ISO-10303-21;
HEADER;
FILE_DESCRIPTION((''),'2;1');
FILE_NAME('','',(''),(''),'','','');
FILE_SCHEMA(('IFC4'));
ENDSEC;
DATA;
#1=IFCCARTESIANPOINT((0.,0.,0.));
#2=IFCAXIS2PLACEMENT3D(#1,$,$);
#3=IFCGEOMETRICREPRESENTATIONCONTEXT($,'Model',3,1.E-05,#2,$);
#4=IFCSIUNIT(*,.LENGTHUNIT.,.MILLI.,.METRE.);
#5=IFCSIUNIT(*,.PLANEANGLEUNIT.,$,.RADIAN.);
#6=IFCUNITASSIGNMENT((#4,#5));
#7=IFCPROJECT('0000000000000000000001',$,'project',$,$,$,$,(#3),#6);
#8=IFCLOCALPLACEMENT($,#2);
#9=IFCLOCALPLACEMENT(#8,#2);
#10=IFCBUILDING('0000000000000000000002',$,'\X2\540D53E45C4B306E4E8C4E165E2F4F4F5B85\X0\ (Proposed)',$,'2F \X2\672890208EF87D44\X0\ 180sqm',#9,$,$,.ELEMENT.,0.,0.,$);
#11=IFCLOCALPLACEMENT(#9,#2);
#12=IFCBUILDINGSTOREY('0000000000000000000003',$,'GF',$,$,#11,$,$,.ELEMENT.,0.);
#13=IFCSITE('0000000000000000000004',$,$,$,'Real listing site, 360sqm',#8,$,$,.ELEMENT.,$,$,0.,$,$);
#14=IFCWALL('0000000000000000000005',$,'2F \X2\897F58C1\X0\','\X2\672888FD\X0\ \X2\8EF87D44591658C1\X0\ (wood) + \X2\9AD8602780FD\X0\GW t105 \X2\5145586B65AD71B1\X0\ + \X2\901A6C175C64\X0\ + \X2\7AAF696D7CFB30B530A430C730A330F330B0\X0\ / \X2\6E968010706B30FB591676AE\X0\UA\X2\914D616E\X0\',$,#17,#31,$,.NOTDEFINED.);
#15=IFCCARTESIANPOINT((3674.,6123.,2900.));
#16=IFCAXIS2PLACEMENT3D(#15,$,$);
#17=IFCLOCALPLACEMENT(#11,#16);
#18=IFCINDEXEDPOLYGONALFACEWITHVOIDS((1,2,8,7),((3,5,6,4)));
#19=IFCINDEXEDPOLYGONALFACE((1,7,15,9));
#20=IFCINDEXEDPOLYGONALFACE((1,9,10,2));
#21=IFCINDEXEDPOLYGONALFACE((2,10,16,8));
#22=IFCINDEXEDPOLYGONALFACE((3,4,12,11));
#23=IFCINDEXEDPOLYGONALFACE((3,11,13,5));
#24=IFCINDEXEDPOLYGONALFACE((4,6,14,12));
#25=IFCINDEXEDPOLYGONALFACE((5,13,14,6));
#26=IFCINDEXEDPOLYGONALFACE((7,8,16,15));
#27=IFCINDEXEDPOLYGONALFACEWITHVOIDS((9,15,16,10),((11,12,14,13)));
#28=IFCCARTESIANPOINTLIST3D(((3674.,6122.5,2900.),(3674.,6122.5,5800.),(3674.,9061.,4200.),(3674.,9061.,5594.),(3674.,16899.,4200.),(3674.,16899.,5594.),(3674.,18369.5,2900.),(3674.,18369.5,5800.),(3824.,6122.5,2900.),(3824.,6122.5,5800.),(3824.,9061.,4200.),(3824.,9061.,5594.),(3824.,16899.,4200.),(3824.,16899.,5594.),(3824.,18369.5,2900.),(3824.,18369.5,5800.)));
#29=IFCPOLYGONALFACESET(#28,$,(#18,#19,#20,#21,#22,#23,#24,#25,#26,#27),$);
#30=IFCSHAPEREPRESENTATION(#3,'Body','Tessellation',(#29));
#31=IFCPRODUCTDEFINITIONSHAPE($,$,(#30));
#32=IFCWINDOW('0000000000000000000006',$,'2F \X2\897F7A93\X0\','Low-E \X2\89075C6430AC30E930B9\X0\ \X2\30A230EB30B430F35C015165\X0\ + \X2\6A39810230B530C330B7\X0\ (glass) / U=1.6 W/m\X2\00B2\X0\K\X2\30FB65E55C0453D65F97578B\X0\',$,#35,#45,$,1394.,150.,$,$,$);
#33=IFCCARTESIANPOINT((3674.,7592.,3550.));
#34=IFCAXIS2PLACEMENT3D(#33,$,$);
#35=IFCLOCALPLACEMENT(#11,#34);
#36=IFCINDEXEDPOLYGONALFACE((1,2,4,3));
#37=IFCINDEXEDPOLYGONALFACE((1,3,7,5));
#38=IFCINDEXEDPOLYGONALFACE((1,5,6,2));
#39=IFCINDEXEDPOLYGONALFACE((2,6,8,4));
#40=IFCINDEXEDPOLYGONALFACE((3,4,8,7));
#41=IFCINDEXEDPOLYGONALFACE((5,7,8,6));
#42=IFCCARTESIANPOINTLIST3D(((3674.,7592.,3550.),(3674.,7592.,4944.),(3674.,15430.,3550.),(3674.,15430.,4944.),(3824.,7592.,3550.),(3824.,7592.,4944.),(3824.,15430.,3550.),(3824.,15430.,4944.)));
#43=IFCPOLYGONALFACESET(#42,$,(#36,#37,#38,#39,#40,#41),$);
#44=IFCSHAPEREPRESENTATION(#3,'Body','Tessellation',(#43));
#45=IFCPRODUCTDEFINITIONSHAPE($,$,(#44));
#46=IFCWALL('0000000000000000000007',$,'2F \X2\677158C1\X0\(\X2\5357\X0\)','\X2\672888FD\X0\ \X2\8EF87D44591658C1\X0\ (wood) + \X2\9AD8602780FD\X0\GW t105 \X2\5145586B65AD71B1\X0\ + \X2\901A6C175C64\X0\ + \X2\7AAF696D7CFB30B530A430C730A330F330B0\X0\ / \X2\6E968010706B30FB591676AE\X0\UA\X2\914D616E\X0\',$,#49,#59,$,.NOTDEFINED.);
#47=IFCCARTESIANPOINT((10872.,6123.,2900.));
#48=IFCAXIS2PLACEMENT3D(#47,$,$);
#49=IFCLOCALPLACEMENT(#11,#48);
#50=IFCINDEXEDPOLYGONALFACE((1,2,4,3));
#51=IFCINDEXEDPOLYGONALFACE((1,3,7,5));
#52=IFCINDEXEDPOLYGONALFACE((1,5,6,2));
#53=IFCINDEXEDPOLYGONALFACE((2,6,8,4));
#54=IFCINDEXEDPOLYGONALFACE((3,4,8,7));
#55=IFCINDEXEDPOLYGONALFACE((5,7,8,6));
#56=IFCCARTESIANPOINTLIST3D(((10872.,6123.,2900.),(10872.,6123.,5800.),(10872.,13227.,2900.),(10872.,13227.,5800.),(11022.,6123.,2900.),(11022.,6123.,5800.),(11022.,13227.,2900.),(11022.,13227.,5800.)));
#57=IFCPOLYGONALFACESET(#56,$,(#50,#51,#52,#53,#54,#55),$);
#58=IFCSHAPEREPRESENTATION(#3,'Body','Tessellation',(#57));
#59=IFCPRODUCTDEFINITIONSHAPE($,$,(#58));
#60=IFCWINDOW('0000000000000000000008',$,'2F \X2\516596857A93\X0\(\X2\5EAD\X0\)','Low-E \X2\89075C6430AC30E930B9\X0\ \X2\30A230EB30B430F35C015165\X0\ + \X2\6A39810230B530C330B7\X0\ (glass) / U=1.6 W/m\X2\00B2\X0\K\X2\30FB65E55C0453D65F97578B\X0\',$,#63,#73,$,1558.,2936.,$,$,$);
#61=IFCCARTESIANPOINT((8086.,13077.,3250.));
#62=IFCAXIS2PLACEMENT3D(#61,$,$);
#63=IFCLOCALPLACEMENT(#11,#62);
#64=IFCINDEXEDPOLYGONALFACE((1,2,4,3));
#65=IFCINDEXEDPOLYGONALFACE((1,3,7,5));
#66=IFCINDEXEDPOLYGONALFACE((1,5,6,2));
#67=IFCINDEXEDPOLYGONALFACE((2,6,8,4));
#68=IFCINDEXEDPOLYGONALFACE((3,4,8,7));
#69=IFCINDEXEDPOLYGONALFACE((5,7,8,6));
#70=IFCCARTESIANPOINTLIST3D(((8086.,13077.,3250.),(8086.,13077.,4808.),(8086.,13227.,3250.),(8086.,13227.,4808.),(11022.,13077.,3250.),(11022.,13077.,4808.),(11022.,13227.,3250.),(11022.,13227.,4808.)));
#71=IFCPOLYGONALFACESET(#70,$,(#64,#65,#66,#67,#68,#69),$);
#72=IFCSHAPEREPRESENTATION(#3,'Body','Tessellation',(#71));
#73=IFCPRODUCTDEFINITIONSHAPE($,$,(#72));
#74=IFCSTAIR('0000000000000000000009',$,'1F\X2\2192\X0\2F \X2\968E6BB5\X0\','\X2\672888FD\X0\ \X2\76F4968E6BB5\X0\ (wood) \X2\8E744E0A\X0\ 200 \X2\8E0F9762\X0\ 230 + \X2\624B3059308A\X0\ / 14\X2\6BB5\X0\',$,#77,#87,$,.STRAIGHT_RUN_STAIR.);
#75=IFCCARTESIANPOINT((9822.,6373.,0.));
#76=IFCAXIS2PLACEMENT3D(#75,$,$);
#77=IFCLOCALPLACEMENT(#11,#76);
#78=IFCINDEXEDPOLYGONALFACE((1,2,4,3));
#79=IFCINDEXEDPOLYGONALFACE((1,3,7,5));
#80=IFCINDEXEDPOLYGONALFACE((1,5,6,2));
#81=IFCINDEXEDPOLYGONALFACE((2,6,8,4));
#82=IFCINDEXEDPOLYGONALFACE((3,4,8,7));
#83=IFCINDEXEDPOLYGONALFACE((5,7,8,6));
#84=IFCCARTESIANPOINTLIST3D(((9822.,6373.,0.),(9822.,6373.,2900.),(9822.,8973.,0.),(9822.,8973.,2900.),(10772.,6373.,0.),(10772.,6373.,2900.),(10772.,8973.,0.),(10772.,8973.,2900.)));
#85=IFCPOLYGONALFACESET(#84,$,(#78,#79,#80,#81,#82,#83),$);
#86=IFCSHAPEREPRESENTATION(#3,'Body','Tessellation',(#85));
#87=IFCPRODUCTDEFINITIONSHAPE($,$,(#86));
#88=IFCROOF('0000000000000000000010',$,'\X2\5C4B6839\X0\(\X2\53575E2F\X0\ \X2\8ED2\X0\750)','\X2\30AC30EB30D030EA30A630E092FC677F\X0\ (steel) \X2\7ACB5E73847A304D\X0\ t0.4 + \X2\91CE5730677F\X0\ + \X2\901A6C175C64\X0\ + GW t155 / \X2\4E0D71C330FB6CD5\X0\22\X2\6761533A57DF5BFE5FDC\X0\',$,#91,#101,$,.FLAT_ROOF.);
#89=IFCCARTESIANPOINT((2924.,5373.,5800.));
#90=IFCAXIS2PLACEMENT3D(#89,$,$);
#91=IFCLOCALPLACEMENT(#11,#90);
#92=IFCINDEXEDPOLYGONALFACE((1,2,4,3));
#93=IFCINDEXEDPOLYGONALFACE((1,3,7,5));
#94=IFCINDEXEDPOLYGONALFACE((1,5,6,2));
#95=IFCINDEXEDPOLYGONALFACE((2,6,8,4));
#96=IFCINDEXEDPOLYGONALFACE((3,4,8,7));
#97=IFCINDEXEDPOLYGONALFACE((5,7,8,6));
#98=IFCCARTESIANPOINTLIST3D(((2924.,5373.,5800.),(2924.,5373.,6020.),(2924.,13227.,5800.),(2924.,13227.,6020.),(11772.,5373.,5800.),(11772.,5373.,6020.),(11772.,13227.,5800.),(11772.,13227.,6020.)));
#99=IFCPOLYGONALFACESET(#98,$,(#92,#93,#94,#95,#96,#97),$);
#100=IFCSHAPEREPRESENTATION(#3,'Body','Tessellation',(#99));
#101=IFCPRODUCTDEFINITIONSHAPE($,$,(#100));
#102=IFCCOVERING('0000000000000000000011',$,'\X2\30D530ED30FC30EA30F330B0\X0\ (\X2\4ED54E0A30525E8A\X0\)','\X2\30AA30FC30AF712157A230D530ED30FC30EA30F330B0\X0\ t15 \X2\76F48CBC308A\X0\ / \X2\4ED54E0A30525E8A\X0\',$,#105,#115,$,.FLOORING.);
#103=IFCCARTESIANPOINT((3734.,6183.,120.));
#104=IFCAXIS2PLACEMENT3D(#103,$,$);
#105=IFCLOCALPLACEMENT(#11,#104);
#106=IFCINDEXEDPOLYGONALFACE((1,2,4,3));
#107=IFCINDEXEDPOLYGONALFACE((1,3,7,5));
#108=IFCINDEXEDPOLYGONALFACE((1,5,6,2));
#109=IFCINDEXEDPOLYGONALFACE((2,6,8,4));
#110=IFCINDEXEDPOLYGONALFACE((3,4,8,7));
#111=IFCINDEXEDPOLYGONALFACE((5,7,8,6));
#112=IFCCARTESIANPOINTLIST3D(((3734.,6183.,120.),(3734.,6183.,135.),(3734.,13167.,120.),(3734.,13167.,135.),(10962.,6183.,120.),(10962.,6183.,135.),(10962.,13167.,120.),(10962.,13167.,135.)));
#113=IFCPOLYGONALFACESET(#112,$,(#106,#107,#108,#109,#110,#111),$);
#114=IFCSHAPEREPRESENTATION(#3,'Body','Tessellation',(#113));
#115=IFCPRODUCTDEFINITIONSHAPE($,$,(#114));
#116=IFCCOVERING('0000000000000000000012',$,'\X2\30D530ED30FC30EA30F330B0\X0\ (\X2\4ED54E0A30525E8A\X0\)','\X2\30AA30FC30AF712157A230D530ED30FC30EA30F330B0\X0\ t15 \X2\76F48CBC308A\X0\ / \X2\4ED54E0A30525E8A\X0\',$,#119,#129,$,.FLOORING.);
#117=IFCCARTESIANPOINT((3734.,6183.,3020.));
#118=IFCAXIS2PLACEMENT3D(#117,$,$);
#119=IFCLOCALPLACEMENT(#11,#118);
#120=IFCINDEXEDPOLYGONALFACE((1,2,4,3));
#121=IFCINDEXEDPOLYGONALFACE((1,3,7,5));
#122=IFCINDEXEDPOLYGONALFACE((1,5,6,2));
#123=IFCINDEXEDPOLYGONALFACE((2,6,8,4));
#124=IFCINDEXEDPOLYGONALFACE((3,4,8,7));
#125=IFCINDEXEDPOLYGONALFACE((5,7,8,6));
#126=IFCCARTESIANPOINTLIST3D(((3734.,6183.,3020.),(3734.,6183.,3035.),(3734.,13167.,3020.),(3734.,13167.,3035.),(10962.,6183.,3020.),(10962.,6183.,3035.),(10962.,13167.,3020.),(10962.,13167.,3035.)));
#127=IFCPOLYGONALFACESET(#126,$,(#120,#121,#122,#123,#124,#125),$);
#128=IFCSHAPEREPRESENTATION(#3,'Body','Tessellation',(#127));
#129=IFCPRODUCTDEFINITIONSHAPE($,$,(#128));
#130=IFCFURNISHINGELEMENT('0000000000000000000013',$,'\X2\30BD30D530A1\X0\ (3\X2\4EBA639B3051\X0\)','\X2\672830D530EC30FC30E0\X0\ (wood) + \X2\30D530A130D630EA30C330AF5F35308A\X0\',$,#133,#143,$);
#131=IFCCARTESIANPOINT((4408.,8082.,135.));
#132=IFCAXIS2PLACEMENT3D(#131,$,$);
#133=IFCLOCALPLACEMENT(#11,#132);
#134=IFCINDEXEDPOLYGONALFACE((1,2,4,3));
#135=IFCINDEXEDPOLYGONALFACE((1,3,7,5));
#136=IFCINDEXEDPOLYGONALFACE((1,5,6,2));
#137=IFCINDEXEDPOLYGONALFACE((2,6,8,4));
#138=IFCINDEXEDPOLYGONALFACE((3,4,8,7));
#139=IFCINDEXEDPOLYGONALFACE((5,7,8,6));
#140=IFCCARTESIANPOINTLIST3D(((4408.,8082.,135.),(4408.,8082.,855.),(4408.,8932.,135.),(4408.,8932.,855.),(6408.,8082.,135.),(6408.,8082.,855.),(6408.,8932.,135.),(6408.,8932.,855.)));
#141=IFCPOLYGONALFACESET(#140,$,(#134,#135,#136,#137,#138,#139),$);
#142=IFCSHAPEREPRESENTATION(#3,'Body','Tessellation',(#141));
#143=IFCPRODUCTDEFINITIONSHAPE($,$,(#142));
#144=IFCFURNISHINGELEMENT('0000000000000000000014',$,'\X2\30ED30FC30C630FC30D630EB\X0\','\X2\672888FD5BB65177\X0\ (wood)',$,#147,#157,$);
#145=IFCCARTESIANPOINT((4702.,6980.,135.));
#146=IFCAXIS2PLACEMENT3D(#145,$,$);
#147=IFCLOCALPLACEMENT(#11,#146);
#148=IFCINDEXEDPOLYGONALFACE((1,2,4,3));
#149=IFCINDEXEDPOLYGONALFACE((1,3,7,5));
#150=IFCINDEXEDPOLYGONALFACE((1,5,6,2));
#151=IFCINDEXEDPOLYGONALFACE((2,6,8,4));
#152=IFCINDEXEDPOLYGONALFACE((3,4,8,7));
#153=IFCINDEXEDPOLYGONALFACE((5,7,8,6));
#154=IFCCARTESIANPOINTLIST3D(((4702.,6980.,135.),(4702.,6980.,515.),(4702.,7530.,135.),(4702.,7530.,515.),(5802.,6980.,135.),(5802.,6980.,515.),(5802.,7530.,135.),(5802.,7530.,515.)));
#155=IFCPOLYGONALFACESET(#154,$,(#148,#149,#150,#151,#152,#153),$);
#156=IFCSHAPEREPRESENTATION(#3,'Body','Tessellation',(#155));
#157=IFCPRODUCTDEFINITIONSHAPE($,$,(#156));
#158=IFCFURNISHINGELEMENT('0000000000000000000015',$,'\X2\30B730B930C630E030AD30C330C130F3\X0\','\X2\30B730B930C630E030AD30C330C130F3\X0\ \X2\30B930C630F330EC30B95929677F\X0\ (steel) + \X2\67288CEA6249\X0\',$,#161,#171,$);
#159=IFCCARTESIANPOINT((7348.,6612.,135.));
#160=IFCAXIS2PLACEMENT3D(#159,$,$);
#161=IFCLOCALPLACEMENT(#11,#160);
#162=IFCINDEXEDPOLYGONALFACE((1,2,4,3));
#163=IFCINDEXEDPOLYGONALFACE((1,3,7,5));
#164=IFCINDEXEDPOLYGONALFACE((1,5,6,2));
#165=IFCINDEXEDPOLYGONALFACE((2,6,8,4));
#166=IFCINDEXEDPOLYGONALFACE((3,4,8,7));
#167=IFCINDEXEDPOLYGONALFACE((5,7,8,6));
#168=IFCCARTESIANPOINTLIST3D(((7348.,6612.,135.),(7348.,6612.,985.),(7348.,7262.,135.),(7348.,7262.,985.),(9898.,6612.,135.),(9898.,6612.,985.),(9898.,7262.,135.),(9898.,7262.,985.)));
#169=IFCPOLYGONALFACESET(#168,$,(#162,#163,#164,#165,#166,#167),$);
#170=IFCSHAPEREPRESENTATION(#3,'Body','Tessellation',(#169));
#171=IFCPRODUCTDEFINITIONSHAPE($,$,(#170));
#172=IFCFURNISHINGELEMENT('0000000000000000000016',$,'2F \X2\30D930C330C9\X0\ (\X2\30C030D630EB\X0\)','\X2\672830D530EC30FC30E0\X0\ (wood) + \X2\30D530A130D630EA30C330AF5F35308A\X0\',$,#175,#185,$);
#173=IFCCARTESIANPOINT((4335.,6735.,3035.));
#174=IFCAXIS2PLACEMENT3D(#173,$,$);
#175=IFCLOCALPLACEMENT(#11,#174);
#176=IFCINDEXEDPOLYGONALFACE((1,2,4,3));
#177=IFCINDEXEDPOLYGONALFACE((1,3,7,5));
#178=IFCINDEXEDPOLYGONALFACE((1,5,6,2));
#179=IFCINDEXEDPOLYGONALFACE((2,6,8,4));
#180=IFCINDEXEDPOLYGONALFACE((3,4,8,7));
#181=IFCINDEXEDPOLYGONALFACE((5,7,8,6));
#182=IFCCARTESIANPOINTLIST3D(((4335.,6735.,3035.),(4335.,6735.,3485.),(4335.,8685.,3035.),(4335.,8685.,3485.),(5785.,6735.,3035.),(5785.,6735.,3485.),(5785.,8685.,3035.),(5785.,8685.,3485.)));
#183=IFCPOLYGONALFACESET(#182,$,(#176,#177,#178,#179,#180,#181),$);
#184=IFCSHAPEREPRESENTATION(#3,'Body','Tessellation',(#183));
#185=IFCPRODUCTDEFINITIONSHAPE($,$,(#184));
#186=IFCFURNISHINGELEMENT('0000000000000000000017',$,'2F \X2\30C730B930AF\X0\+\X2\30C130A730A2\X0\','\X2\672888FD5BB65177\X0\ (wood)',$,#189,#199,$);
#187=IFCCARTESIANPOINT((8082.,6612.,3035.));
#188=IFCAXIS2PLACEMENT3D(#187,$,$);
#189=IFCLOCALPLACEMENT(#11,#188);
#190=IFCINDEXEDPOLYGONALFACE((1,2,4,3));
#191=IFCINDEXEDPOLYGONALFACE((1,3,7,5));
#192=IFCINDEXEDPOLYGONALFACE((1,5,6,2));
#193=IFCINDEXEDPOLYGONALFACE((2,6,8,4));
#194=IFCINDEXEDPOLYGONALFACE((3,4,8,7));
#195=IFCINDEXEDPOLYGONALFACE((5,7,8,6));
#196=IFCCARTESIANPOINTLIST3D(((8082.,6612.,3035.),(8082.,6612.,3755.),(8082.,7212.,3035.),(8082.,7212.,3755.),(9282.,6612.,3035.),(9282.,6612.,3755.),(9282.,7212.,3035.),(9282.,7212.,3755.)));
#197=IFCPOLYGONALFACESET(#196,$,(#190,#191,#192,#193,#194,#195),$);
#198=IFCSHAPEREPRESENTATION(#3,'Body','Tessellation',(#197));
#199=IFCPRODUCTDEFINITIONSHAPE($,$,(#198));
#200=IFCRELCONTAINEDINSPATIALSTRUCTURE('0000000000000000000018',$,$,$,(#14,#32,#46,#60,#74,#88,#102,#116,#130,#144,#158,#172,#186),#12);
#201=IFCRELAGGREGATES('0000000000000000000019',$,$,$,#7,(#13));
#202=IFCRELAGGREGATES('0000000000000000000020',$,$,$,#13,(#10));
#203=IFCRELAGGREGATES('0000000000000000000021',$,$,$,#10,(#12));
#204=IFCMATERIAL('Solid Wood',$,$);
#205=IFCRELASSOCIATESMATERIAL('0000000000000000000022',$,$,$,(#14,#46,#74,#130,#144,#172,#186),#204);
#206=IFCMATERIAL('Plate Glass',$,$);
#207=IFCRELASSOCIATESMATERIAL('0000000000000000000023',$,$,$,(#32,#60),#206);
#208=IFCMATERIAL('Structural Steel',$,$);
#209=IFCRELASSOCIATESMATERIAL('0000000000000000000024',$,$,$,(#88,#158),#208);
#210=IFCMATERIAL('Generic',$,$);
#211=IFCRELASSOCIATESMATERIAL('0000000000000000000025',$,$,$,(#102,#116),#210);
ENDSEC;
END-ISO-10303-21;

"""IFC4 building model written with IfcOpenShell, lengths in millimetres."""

from ifc_helpers import new_model, si_unit, frame, frame_2d, origin, place, context, project, spatial, rectangle, extrude, material, element, fill, save


model = new_model("IFC4")

# Units and contexts
model_context = context("Model", 3, precision=1e-05, world=origin())
ifc_project = project(units=[si_unit("LENGTHUNIT", "METRE", prefix="MILLI"), si_unit("PLANEANGLEUNIT", "RADIAN")], contexts=[model_context])

# Site, building, storey
site_placement = place(None, origin())
site = spatial("IfcSite", under=ifc_project, at=site_placement, ObjectType="Real listing site, 360sqm", CompositionType="ELEMENT", RefElevation=0.0)
building_placement = place(site_placement, origin())
building = spatial("IfcBuilding", under=site, at=building_placement, Name="名古屋の二世帯住宅 (Proposed)", ObjectType="2F 木造軸組 180sqm", CompositionType="ELEMENT", ElevationOfRefHeight=0.0, ElevationOfTerrain=0.0)
storey_placement = place(building_placement, origin())
storey = spatial("IfcBuildingStorey", under=building, at=storey_placement, Name="GF", CompositionType="ELEMENT", Elevation=0.0)

# Shared definitions
ifc_material_1 = material(Name="Solid Wood")

# Shared definitions
ifc_material_2 = material(Name="Plate Glass")

# Walls, openings, windows
wall_1_placement = place(storey_placement, frame((3674.0, 6123.0, 2900.0)))
wall_1 = element("IfcWall", 1, at=wall_1_placement, inside=storey, material=ifc_material_1, Name="2F 西壁", Description="木製 軸組外壁 (wood) + 高性能GW t105 充填断熱 + 通気層 + 窯業系サイディング / 準耐火・外皮UA配慮", PredefinedType="NOTDEFINED", context=model_context, shape_type="SweptSolid", body=[
    extrude(rectangle(XDim=150.0, YDim=12247.0, at=frame_2d((75.0, 6123.0))), frame((3674.0, 6123.0, 2900.0)), (0.0, 0.0, 1.0), 2900.0),
])
opening_1_placement = place(storey_placement, frame((3674.0, 7592.0, 3550.0)))
opening_1 = element("IfcOpeningElement", 2, at=opening_1_placement, cuts=wall_1, PredefinedType="NOTDEFINED", context=model_context, shape_type="SweptSolid", body=[
    extrude(rectangle(XDim=150.0, YDim=7838.0, at=frame_2d((75.0, 3919.0))), frame((3674.0, 7592.0, 3550.0)), (0.0, 0.0, 1.0), 1394.0),
])
window_1_placement = place(storey_placement, frame((3674.0, 7592.0, 3550.0)))
window_1 = element("IfcWindow", 3, at=window_1_placement, inside=storey, material=ifc_material_2, Name="2F 西窓", Description="Low-E 複層ガラス アルゴン封入 + 樹脂サッシ (glass) / U=1.6 W/m²K・日射取得型", OverallHeight=1394.0, OverallWidth=150.0, context=model_context, shape_type="SweptSolid", body=[
    extrude(rectangle(XDim=150.0, YDim=7838.0, at=frame_2d((75.0, 3919.0))), frame((3674.0, 7592.0, 3550.0)), (0.0, 0.0, 1.0), 1394.0),
])
fill(opening_1, window_1)
wall_2_placement = place(storey_placement, frame((10872.0, 6123.0, 2900.0)))
wall_2 = element("IfcWall", 4, at=wall_2_placement, inside=storey, material=ifc_material_1, Name="2F 東壁(南)", Description="木製 軸組外壁 (wood) + 高性能GW t105 充填断熱 + 通気層 + 窯業系サイディング / 準耐火・外皮UA配慮", PredefinedType="NOTDEFINED", context=model_context, shape_type="SweptSolid", body=[
    extrude(rectangle(XDim=150.0, YDim=7104.0, at=frame_2d((75.0, 3552.0))), frame((10872.0, 6123.0, 2900.0)), (0.0, 0.0, 1.0), 2900.0),
])
opening_2_placement = place(storey_placement, frame((8086.0, 13077.0, 3250.0)))
opening_2 = element("IfcOpeningElement", 5, at=opening_2_placement, cuts=wall_2, PredefinedType="NOTDEFINED", context=model_context, shape_type="SweptSolid", body=[
    extrude(rectangle(XDim=2936.0, YDim=150.0, at=frame_2d((1468.0, 75.0))), frame((8086.0, 13077.0, 3250.0)), (0.0, 0.0, 1.0), 1558.0),
])
window_2_placement = place(storey_placement, frame((8086.0, 13077.0, 3250.0)))
window_2 = element("IfcWindow", 6, at=window_2_placement, inside=storey, material=ifc_material_2, Name="2F 入隅窓(庭)", Description="Low-E 複層ガラス アルゴン封入 + 樹脂サッシ (glass) / U=1.6 W/m²K・日射取得型", OverallHeight=1558.0, OverallWidth=2936.0, context=model_context, shape_type="SweptSolid", body=[
    extrude(rectangle(XDim=2936.0, YDim=150.0, at=frame_2d((1468.0, 75.0))), frame((8086.0, 13077.0, 3250.0)), (0.0, 0.0, 1.0), 1558.0),
])
fill(opening_2, window_2)

# Stair
stair_placement = place(storey_placement, frame((9822.0, 6373.0, 0.0)))
element("IfcStair", 7, at=stair_placement, inside=storey, material=ifc_material_1, Name="1F→2F 階段", Description="木製 直階段 (wood) 蹴上 200 踏面 230 + 手すり / 14段", PredefinedType="STRAIGHT_RUN_STAIR", context=model_context, shape_type="SweptSolid", body=[
    extrude(rectangle(XDim=950.0, YDim=2600.0, at=frame_2d((475.0, 1300.0))), frame((9822.0, 6373.0, 0.0)), (0.0, 0.0, 1.0), 2900.0),
])

# Roof
ifc_material_3 = material(Name="Structural Steel")
for number, where, name in (
    (8, (2924.0, 5373.0, 5800.0), "屋根(南帯 軒750)"),
):
    element("IfcRoof", number, at=place(storey_placement, frame(where)), inside=storey, material=ifc_material_3, Name=name, Description="ガルバリウム鋼板 (steel) 立平葺き t0.4 + 野地板 + 通気層 + GW t155 / 不燃・法22条区域対応", PredefinedType="FLAT_ROOF", context=model_context, shape_type="SweptSolid", body=[
        extrude(rectangle(XDim=8848.0, YDim=7854.0, at=frame_2d((4424.0, 3927.0))), frame((2924.0, 5373.0, 5800.0)), (0.0, 0.0, 1.0), 220.0),
    ])

# Coverings
ifc_material_4 = material(Name="Generic")
covering_1_placement = place(storey_placement, frame((3734.0, 6183.0, 120.0)))
element("IfcCovering", 9, at=covering_1_placement, inside=storey, material=ifc_material_4, Name="フローリング (仕上げ床)", Description="オーク無垢フローリング t15 直貼り / 仕上げ床", PredefinedType="FLOORING", context=model_context, shape_type="SweptSolid", body=[
    extrude(rectangle(XDim=7228.0, YDim=6984.0, at=frame_2d((3614.0, 3492.0))), frame((3734.0, 6183.0, 120.0)), (0.0, 0.0, 1.0), 15.0),
])
covering_2_placement = place(storey_placement, frame((3734.0, 6183.0, 3020.0)))
element("IfcCovering", 10, at=covering_2_placement, inside=storey, material=ifc_material_4, Name="フローリング (仕上げ床)", Description="オーク無垢フローリング t15 直貼り / 仕上げ床", PredefinedType="FLOORING", context=model_context, shape_type="SweptSolid", body=[
    extrude(rectangle(XDim=7228.0, YDim=6984.0, at=frame_2d((3614.0, 3492.0))), frame((3734.0, 6183.0, 3020.0)), (0.0, 0.0, 1.0), 15.0),
])

# Furnishing elements
furnishing_1_placement = place(storey_placement, frame((4408.0, 8082.0, 135.0)))
element("IfcFurnishingElement", 11, at=furnishing_1_placement, inside=storey, material=ifc_material_1, Name="ソファ (3人掛け)", Description="木フレーム (wood) + ファブリック張り", context=model_context, shape_type="SweptSolid", body=[
    extrude(rectangle(XDim=2000.0, YDim=850.0, at=frame_2d((1000.0, 425.0))), frame((4408.0, 8082.0, 135.0)), (0.0, 0.0, 1.0), 720.0),
])
furnishing_2_placement = place(storey_placement, frame((4702.0, 6980.0, 135.0)))
element("IfcFurnishingElement", 12, at=furnishing_2_placement, inside=storey, material=ifc_material_1, Name="ローテーブル", Description="木製家具 (wood)", context=model_context, shape_type="SweptSolid", body=[
    extrude(rectangle(XDim=1100.0, YDim=550.0, at=frame_2d((550.0, 275.0))), frame((4702.0, 6980.0, 135.0)), (0.0, 0.0, 1.0), 380.0),
])
furnishing_3_placement = place(storey_placement, frame((7348.0, 6612.0, 135.0)))
element("IfcFurnishingElement", 13, at=furnishing_3_placement, inside=storey, material=ifc_material_3, Name="システムキッチン", Description="システムキッチン ステンレス天板 (steel) + 木質扉", context=model_context, shape_type="SweptSolid", body=[
    extrude(rectangle(XDim=2550.0, YDim=650.0, at=frame_2d((1275.0, 325.0))), frame((7348.0, 6612.0, 135.0)), (0.0, 0.0, 1.0), 850.0),
])
furnishing_4_placement = place(storey_placement, frame((4335.0, 6735.0, 3035.0)))
element("IfcFurnishingElement", 14, at=furnishing_4_placement, inside=storey, material=ifc_material_1, Name="2F ベッド (ダブル)", Description="木フレーム (wood) + ファブリック張り", context=model_context, shape_type="SweptSolid", body=[
    extrude(rectangle(XDim=1450.0, YDim=1950.0, at=frame_2d((725.0, 975.0))), frame((4335.0, 6735.0, 3035.0)), (0.0, 0.0, 1.0), 450.0),
])
furnishing_5_placement = place(storey_placement, frame((8082.0, 6612.0, 3035.0)))
element("IfcFurnishingElement", 15, at=furnishing_5_placement, inside=storey, material=ifc_material_1, Name="2F デスク+チェア", Description="木製家具 (wood)", context=model_context, shape_type="SweptSolid", body=[
    extrude(rectangle(XDim=1200.0, YDim=600.0, at=frame_2d((600.0, 300.0))), frame((8082.0, 6612.0, 3035.0)), (0.0, 0.0, 1.0), 720.0),
])

save(model, "model.ifc")
